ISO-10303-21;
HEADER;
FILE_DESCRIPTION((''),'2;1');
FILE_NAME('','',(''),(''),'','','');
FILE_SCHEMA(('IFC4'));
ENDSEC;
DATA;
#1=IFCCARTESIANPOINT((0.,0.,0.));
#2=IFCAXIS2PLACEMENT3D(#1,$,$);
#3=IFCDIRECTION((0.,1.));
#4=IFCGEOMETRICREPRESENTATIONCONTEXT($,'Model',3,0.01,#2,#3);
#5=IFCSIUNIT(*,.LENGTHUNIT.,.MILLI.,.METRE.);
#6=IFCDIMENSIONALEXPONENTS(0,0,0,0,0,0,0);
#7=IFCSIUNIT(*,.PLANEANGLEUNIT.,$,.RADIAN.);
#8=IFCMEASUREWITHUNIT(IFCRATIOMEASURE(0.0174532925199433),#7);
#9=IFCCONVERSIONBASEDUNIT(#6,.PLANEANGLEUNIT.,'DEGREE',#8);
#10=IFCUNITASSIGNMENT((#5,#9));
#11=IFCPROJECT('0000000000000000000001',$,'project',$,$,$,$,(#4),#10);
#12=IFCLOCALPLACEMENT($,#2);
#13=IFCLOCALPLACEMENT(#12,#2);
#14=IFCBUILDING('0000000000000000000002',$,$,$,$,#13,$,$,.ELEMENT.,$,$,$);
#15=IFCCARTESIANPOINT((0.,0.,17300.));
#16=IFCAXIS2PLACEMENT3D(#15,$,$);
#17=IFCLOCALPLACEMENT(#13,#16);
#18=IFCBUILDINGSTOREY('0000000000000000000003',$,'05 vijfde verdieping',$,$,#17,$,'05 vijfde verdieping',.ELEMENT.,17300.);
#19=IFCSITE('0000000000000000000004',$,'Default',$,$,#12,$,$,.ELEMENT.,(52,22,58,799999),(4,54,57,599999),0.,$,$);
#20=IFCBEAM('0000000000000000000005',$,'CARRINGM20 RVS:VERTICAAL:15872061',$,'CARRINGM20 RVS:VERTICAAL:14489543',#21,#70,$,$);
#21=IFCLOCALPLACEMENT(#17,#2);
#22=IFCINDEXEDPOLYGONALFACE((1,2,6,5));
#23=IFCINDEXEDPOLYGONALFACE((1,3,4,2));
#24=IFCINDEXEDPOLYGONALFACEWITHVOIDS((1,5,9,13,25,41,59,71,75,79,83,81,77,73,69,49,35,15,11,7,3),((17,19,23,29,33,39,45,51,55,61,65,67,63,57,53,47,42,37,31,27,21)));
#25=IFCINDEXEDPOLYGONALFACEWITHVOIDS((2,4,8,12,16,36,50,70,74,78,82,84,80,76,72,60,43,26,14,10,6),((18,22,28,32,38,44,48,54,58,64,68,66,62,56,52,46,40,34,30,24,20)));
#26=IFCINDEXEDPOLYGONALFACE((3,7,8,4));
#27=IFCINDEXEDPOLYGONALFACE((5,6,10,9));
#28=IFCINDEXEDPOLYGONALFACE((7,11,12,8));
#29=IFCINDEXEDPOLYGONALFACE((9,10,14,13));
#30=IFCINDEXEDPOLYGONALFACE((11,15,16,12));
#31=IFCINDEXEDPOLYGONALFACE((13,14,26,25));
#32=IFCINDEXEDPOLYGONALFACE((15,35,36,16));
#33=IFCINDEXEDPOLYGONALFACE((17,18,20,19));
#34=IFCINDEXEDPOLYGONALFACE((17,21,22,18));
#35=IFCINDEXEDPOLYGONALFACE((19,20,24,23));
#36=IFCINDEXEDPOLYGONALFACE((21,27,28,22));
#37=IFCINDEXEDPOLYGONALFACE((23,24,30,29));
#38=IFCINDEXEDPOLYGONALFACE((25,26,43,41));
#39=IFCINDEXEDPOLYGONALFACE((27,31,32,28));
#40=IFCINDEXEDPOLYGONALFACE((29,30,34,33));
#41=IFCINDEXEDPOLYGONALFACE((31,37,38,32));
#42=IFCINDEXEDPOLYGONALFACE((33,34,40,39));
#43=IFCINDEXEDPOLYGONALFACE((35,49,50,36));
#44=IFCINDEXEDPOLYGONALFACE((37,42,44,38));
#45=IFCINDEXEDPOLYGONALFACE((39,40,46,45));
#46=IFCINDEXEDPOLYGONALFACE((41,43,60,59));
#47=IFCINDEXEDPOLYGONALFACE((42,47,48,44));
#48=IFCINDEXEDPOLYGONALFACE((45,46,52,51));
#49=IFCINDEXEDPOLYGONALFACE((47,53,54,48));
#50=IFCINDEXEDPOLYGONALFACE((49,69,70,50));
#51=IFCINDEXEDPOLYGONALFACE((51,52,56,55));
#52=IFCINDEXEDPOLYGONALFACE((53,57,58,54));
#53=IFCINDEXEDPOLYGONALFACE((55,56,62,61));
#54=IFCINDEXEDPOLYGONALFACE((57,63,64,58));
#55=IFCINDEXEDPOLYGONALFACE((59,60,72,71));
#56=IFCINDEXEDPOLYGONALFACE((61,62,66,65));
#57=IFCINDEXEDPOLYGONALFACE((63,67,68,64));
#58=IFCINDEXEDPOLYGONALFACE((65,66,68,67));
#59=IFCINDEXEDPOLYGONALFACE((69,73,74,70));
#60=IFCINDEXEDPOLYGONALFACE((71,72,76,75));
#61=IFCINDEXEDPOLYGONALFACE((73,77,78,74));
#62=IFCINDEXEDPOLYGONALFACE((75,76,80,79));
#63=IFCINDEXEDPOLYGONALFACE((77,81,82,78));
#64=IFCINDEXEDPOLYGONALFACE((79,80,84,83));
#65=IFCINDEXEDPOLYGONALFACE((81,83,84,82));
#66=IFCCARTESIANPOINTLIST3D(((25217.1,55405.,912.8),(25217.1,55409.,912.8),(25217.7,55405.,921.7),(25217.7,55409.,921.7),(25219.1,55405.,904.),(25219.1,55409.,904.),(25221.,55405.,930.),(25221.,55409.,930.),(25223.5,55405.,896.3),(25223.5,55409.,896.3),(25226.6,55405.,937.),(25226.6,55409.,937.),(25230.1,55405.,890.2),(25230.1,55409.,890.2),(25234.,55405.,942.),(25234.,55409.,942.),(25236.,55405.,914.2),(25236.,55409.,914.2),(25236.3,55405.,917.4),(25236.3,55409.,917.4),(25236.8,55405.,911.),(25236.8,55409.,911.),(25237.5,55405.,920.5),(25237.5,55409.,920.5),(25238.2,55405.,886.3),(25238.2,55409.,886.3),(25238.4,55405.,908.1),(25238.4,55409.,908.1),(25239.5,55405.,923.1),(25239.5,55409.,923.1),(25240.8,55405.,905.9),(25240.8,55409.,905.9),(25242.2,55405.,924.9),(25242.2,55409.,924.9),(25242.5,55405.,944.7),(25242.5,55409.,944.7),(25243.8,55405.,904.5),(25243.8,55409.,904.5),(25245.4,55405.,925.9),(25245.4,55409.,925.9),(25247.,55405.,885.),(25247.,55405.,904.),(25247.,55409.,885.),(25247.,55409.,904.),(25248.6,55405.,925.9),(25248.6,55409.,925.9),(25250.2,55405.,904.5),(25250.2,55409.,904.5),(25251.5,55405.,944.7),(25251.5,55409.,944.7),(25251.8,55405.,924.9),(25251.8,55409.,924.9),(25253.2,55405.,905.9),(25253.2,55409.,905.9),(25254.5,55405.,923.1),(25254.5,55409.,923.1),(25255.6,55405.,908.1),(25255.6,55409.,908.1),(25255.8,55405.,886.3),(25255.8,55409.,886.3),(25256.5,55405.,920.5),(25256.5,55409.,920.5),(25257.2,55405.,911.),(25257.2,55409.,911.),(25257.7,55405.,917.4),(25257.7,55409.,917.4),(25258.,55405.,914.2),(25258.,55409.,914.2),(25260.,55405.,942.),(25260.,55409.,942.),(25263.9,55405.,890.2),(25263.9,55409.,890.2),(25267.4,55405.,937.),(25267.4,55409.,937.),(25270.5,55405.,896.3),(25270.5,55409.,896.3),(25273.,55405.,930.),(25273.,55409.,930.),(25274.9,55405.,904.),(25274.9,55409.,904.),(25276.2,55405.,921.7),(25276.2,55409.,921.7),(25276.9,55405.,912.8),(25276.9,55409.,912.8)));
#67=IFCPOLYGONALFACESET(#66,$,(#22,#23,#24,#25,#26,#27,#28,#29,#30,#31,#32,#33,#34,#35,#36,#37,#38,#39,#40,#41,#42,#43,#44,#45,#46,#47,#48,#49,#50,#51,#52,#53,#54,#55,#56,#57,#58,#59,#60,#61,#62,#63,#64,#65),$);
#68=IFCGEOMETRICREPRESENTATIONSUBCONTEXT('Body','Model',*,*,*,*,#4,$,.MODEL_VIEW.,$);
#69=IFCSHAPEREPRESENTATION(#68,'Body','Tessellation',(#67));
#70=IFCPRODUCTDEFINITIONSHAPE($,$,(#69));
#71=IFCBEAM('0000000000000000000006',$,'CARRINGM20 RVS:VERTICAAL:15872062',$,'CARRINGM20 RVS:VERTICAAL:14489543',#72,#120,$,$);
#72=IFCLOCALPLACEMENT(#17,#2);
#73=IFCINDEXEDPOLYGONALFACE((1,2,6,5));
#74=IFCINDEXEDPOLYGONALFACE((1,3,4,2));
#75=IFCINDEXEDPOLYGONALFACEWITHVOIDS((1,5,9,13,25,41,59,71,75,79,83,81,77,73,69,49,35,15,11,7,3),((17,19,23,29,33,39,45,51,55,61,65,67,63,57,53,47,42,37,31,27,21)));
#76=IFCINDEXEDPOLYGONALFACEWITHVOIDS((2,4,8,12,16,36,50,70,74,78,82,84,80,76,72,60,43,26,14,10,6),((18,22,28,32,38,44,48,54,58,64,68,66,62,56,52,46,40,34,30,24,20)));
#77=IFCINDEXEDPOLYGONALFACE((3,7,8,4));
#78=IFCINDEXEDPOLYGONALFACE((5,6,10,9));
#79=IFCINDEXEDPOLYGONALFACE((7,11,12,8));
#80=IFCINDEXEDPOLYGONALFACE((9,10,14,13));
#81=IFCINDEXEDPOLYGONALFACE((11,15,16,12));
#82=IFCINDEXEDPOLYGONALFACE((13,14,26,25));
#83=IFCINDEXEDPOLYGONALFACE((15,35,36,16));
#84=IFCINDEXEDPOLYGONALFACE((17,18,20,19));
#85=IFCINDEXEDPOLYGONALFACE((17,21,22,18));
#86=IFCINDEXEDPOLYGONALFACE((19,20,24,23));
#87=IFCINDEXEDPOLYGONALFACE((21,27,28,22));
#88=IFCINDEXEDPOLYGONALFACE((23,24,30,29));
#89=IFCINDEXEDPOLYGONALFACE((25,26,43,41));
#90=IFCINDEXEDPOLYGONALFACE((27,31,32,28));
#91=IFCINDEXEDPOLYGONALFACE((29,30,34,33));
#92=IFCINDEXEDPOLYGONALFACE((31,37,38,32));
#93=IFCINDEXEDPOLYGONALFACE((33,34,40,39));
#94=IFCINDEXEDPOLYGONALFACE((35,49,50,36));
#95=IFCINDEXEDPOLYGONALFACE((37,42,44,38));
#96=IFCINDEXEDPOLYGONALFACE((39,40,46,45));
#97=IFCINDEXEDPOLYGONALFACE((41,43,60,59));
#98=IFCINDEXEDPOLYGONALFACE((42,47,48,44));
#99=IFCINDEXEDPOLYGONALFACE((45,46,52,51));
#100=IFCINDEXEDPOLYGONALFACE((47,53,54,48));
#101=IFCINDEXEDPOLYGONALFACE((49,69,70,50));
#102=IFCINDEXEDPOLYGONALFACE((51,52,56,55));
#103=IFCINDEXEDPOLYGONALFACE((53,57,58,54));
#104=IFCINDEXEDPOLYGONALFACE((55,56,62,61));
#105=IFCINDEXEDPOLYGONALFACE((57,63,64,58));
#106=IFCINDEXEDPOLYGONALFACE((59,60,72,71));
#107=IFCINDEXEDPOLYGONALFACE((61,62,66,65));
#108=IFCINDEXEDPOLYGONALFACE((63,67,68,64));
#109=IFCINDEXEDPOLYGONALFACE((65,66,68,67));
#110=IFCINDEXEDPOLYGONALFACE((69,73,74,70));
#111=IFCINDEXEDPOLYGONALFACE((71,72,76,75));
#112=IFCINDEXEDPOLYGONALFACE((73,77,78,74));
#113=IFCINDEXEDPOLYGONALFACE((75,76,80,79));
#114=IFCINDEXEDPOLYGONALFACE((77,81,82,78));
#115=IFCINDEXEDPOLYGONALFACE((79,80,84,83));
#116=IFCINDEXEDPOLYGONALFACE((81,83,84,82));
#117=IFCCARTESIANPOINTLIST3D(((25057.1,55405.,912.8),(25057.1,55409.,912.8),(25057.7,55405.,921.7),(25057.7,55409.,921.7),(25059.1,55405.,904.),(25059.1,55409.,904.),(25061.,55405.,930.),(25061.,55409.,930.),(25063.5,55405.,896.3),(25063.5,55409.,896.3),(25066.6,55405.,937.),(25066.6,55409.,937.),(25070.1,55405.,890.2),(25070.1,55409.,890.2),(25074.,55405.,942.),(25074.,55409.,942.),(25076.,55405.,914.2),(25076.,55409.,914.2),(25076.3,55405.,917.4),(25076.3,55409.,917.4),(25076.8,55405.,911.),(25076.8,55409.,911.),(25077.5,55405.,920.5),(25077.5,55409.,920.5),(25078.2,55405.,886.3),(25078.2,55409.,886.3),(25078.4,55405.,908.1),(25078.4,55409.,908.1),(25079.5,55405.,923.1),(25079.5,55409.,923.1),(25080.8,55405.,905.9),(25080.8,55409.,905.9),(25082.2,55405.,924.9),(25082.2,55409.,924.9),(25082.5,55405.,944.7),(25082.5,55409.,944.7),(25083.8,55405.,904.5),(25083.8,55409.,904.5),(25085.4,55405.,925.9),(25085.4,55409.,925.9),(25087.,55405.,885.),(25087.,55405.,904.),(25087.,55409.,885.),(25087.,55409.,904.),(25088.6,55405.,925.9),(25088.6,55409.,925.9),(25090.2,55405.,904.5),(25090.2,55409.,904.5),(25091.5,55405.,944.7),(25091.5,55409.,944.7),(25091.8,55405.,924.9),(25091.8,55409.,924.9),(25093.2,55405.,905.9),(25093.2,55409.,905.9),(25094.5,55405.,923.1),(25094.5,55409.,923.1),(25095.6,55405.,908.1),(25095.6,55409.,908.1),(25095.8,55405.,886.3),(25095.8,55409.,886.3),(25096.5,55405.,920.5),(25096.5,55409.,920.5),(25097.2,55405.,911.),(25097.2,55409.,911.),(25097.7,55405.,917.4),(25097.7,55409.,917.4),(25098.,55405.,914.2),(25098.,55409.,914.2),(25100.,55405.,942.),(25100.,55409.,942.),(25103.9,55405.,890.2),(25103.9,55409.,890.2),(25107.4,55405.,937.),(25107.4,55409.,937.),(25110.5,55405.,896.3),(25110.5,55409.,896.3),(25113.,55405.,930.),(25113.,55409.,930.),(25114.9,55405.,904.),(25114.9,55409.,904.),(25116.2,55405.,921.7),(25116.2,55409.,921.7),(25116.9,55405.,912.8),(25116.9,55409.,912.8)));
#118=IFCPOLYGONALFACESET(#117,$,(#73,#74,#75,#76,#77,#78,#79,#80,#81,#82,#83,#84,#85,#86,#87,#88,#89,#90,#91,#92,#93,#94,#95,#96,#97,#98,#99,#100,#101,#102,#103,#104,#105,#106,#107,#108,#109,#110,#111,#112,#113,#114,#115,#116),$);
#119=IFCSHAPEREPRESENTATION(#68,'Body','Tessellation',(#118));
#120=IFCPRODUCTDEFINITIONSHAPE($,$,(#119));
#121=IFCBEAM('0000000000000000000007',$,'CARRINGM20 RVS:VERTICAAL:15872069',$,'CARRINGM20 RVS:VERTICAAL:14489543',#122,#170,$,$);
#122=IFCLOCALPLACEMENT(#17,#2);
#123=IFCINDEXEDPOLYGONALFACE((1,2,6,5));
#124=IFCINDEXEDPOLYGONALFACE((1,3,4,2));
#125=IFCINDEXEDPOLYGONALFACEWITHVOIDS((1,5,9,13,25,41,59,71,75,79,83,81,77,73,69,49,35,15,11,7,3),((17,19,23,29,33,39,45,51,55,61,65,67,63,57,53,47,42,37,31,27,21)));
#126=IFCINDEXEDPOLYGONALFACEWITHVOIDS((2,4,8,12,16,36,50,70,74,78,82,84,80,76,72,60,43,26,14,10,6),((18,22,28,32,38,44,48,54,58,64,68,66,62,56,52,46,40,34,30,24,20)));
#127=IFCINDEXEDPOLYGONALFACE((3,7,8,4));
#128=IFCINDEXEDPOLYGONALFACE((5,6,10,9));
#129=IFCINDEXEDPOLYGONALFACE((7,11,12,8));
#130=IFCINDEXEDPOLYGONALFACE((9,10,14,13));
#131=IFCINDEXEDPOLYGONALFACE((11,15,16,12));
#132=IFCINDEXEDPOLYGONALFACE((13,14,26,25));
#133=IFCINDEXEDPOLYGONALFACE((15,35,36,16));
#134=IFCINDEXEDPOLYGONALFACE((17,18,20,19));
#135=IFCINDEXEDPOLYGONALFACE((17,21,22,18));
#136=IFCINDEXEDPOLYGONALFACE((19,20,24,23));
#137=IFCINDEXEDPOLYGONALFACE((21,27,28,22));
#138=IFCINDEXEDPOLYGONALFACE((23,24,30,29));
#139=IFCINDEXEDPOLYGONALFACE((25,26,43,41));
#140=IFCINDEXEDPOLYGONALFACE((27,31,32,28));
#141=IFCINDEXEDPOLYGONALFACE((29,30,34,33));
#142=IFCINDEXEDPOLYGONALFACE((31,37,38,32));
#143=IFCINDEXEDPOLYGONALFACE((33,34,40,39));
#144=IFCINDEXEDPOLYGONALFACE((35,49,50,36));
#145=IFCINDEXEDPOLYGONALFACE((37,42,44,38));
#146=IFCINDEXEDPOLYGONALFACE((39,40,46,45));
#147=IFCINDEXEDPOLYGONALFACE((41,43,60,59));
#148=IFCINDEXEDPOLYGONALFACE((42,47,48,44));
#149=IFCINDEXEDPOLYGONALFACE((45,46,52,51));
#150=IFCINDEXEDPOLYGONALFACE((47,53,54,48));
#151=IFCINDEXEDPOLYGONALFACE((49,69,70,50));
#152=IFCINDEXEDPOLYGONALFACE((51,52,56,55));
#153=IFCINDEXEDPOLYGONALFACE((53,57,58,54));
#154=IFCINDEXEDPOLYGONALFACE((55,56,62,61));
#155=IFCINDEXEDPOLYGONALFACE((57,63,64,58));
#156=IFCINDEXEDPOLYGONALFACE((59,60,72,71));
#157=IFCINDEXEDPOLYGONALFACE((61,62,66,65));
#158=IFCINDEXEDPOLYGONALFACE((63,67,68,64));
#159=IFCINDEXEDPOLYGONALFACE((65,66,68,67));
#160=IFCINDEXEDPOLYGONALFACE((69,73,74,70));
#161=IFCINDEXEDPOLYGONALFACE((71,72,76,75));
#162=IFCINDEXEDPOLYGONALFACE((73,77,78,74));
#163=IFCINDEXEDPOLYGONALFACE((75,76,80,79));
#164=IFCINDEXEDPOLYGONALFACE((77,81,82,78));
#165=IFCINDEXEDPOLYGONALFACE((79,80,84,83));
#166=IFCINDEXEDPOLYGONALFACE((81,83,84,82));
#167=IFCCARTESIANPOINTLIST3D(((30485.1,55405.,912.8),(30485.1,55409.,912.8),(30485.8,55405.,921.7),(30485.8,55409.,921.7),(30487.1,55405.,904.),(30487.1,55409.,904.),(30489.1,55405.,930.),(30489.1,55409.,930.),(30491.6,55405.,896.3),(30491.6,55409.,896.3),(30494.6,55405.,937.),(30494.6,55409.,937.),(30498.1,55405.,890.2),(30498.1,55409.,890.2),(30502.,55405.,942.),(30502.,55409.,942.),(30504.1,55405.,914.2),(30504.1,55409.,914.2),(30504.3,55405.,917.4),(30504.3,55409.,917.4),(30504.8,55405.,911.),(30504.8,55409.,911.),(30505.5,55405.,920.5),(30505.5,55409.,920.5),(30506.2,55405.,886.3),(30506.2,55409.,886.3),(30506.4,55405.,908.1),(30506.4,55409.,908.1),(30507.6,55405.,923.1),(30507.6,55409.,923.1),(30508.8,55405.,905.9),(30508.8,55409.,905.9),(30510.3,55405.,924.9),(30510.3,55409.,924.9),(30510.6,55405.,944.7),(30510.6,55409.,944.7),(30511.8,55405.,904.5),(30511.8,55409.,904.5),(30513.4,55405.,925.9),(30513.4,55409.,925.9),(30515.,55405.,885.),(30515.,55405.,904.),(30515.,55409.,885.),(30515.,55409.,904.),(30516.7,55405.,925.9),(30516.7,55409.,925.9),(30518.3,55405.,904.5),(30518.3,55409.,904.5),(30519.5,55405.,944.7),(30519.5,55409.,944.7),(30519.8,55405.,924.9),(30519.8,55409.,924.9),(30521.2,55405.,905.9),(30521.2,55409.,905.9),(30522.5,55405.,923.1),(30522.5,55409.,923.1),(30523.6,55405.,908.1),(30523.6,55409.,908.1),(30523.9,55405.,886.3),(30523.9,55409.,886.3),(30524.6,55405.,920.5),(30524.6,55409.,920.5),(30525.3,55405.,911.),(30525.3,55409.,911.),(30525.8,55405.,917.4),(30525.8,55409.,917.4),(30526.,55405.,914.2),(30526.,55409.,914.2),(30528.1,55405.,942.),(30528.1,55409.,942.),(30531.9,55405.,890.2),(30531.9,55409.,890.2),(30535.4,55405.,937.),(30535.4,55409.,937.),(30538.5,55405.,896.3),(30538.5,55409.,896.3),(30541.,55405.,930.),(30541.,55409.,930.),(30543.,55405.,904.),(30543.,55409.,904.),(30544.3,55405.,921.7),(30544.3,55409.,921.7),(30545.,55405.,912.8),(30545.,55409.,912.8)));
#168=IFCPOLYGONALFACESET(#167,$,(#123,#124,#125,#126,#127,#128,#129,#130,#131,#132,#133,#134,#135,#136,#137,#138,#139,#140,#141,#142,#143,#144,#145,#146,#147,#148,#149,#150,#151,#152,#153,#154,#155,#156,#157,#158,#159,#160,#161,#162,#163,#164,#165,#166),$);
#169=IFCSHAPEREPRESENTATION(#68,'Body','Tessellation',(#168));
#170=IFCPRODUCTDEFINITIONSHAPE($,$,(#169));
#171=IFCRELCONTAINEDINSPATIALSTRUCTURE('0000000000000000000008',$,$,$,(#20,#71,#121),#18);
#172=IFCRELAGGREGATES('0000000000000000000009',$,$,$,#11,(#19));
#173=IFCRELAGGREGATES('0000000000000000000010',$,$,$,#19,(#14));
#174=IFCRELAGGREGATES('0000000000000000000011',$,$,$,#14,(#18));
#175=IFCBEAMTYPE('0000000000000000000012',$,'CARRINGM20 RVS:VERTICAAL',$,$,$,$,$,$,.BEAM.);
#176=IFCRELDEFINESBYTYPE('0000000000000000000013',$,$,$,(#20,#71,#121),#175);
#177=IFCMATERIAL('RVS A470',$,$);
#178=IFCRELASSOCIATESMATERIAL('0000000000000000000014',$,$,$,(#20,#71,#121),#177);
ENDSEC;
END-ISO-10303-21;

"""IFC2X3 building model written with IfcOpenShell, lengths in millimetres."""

from ifc_helpers import new_model, entity, si_unit, converted_unit, direction, frame, origin, origin_2d_with_axis, place, context, subcontext, project, spatial, hollow_circle, extrude, material, type_object, element, save


model = new_model("IFC2X3")

# Units and contexts
model_context = context("Model", 3, precision=0.01, world=origin(), true_north=direction((0.0, 1.0)))
body_context = subcontext(model_context, "Body", "Model", "MODEL_VIEW")
ifc_project = project(units=[si_unit("LENGTHUNIT", "METRE", prefix="MILLI"), converted_unit("PLANEANGLEUNIT", "DEGREE", entity("IfcRatioMeasure", 0.0174532925199433), si_unit("PLANEANGLEUNIT", "RADIAN"), dimensions=[0, 0, 0, 0, 0, 0, 0])], contexts=[model_context])

# Site, building, storey
site_placement = place(None, origin())
site = spatial("IfcSite", under=ifc_project, at=site_placement, Name="Default", CompositionType="ELEMENT", RefLatitude=(52, 22, 58, 799999), RefLongitude=(4, 54, 57, 599999), RefElevation=0.0)
building_placement = place(site_placement, origin())
building = spatial("IfcBuilding", under=site, at=building_placement, CompositionType="ELEMENT")
storey_placement = place(building_placement, frame((0.0, 0.0, 17300.0)))
storey = spatial("IfcBuildingStorey", under=building, at=storey_placement, Name="05 vijfde verdieping", LongName="05 vijfde verdieping", CompositionType="ELEMENT", Elevation=17300.0)

# Beams
ifc_material_1 = material(Name="RVS A470")
beam_type_1 = type_object("IfcBeamType", Name="CARRINGM20 RVS:VERTICAAL", PredefinedType="BEAM")
beam_1_placement = place(storey_placement, origin())
element("IfcBeam", 1, at=beam_1_placement, inside=storey, type_object=beam_type_1, material=ifc_material_1, Name="CARRINGM20 RVS:VERTICAAL:15872061", ObjectType="CARRINGM20 RVS:VERTICAAL:14489543", context=body_context, shape_type="SweptSolid", body=[
    extrude(hollow_circle(Radius=30.0, WallThickness=19.0, at=origin_2d_with_axis()), frame((25247.0, 55405.0, 915.0), z_axis=(0.0, 1.0, 0.0), x_axis=(0.0, 0.0, -1.0)), (0.0, 0.0, 1.0), 4.0),
])
beam_2_placement = place(storey_placement, origin())
element("IfcBeam", 2, at=beam_2_placement, inside=storey, type_object=beam_type_1, material=ifc_material_1, Name="CARRINGM20 RVS:VERTICAAL:15872062", ObjectType="CARRINGM20 RVS:VERTICAAL:14489543", context=body_context, shape_type="SweptSolid", body=[
    extrude(hollow_circle(Radius=30.0, WallThickness=19.0, at=origin_2d_with_axis()), frame((25087.0, 55405.0, 915.0), z_axis=(0.0, 1.0, 0.0), x_axis=(0.0, 0.0, -1.0)), (0.0, 0.0, 1.0), 4.0),
])
beam_3_placement = place(storey_placement, origin())
element("IfcBeam", 3, at=beam_3_placement, inside=storey, type_object=beam_type_1, material=ifc_material_1, Name="CARRINGM20 RVS:VERTICAAL:15872069", ObjectType="CARRINGM20 RVS:VERTICAAL:14489543", context=body_context, shape_type="SweptSolid", body=[
    extrude(hollow_circle(Radius=30.0, WallThickness=19.0, at=origin_2d_with_axis()), frame((30515.0, 55405.0, 915.0), z_axis=(0.0, 1.0, 0.0), x_axis=(0.0, 0.0, -1.0)), (0.0, 0.0, 1.0), 4.0),
])

save(model, "model.ifc")
